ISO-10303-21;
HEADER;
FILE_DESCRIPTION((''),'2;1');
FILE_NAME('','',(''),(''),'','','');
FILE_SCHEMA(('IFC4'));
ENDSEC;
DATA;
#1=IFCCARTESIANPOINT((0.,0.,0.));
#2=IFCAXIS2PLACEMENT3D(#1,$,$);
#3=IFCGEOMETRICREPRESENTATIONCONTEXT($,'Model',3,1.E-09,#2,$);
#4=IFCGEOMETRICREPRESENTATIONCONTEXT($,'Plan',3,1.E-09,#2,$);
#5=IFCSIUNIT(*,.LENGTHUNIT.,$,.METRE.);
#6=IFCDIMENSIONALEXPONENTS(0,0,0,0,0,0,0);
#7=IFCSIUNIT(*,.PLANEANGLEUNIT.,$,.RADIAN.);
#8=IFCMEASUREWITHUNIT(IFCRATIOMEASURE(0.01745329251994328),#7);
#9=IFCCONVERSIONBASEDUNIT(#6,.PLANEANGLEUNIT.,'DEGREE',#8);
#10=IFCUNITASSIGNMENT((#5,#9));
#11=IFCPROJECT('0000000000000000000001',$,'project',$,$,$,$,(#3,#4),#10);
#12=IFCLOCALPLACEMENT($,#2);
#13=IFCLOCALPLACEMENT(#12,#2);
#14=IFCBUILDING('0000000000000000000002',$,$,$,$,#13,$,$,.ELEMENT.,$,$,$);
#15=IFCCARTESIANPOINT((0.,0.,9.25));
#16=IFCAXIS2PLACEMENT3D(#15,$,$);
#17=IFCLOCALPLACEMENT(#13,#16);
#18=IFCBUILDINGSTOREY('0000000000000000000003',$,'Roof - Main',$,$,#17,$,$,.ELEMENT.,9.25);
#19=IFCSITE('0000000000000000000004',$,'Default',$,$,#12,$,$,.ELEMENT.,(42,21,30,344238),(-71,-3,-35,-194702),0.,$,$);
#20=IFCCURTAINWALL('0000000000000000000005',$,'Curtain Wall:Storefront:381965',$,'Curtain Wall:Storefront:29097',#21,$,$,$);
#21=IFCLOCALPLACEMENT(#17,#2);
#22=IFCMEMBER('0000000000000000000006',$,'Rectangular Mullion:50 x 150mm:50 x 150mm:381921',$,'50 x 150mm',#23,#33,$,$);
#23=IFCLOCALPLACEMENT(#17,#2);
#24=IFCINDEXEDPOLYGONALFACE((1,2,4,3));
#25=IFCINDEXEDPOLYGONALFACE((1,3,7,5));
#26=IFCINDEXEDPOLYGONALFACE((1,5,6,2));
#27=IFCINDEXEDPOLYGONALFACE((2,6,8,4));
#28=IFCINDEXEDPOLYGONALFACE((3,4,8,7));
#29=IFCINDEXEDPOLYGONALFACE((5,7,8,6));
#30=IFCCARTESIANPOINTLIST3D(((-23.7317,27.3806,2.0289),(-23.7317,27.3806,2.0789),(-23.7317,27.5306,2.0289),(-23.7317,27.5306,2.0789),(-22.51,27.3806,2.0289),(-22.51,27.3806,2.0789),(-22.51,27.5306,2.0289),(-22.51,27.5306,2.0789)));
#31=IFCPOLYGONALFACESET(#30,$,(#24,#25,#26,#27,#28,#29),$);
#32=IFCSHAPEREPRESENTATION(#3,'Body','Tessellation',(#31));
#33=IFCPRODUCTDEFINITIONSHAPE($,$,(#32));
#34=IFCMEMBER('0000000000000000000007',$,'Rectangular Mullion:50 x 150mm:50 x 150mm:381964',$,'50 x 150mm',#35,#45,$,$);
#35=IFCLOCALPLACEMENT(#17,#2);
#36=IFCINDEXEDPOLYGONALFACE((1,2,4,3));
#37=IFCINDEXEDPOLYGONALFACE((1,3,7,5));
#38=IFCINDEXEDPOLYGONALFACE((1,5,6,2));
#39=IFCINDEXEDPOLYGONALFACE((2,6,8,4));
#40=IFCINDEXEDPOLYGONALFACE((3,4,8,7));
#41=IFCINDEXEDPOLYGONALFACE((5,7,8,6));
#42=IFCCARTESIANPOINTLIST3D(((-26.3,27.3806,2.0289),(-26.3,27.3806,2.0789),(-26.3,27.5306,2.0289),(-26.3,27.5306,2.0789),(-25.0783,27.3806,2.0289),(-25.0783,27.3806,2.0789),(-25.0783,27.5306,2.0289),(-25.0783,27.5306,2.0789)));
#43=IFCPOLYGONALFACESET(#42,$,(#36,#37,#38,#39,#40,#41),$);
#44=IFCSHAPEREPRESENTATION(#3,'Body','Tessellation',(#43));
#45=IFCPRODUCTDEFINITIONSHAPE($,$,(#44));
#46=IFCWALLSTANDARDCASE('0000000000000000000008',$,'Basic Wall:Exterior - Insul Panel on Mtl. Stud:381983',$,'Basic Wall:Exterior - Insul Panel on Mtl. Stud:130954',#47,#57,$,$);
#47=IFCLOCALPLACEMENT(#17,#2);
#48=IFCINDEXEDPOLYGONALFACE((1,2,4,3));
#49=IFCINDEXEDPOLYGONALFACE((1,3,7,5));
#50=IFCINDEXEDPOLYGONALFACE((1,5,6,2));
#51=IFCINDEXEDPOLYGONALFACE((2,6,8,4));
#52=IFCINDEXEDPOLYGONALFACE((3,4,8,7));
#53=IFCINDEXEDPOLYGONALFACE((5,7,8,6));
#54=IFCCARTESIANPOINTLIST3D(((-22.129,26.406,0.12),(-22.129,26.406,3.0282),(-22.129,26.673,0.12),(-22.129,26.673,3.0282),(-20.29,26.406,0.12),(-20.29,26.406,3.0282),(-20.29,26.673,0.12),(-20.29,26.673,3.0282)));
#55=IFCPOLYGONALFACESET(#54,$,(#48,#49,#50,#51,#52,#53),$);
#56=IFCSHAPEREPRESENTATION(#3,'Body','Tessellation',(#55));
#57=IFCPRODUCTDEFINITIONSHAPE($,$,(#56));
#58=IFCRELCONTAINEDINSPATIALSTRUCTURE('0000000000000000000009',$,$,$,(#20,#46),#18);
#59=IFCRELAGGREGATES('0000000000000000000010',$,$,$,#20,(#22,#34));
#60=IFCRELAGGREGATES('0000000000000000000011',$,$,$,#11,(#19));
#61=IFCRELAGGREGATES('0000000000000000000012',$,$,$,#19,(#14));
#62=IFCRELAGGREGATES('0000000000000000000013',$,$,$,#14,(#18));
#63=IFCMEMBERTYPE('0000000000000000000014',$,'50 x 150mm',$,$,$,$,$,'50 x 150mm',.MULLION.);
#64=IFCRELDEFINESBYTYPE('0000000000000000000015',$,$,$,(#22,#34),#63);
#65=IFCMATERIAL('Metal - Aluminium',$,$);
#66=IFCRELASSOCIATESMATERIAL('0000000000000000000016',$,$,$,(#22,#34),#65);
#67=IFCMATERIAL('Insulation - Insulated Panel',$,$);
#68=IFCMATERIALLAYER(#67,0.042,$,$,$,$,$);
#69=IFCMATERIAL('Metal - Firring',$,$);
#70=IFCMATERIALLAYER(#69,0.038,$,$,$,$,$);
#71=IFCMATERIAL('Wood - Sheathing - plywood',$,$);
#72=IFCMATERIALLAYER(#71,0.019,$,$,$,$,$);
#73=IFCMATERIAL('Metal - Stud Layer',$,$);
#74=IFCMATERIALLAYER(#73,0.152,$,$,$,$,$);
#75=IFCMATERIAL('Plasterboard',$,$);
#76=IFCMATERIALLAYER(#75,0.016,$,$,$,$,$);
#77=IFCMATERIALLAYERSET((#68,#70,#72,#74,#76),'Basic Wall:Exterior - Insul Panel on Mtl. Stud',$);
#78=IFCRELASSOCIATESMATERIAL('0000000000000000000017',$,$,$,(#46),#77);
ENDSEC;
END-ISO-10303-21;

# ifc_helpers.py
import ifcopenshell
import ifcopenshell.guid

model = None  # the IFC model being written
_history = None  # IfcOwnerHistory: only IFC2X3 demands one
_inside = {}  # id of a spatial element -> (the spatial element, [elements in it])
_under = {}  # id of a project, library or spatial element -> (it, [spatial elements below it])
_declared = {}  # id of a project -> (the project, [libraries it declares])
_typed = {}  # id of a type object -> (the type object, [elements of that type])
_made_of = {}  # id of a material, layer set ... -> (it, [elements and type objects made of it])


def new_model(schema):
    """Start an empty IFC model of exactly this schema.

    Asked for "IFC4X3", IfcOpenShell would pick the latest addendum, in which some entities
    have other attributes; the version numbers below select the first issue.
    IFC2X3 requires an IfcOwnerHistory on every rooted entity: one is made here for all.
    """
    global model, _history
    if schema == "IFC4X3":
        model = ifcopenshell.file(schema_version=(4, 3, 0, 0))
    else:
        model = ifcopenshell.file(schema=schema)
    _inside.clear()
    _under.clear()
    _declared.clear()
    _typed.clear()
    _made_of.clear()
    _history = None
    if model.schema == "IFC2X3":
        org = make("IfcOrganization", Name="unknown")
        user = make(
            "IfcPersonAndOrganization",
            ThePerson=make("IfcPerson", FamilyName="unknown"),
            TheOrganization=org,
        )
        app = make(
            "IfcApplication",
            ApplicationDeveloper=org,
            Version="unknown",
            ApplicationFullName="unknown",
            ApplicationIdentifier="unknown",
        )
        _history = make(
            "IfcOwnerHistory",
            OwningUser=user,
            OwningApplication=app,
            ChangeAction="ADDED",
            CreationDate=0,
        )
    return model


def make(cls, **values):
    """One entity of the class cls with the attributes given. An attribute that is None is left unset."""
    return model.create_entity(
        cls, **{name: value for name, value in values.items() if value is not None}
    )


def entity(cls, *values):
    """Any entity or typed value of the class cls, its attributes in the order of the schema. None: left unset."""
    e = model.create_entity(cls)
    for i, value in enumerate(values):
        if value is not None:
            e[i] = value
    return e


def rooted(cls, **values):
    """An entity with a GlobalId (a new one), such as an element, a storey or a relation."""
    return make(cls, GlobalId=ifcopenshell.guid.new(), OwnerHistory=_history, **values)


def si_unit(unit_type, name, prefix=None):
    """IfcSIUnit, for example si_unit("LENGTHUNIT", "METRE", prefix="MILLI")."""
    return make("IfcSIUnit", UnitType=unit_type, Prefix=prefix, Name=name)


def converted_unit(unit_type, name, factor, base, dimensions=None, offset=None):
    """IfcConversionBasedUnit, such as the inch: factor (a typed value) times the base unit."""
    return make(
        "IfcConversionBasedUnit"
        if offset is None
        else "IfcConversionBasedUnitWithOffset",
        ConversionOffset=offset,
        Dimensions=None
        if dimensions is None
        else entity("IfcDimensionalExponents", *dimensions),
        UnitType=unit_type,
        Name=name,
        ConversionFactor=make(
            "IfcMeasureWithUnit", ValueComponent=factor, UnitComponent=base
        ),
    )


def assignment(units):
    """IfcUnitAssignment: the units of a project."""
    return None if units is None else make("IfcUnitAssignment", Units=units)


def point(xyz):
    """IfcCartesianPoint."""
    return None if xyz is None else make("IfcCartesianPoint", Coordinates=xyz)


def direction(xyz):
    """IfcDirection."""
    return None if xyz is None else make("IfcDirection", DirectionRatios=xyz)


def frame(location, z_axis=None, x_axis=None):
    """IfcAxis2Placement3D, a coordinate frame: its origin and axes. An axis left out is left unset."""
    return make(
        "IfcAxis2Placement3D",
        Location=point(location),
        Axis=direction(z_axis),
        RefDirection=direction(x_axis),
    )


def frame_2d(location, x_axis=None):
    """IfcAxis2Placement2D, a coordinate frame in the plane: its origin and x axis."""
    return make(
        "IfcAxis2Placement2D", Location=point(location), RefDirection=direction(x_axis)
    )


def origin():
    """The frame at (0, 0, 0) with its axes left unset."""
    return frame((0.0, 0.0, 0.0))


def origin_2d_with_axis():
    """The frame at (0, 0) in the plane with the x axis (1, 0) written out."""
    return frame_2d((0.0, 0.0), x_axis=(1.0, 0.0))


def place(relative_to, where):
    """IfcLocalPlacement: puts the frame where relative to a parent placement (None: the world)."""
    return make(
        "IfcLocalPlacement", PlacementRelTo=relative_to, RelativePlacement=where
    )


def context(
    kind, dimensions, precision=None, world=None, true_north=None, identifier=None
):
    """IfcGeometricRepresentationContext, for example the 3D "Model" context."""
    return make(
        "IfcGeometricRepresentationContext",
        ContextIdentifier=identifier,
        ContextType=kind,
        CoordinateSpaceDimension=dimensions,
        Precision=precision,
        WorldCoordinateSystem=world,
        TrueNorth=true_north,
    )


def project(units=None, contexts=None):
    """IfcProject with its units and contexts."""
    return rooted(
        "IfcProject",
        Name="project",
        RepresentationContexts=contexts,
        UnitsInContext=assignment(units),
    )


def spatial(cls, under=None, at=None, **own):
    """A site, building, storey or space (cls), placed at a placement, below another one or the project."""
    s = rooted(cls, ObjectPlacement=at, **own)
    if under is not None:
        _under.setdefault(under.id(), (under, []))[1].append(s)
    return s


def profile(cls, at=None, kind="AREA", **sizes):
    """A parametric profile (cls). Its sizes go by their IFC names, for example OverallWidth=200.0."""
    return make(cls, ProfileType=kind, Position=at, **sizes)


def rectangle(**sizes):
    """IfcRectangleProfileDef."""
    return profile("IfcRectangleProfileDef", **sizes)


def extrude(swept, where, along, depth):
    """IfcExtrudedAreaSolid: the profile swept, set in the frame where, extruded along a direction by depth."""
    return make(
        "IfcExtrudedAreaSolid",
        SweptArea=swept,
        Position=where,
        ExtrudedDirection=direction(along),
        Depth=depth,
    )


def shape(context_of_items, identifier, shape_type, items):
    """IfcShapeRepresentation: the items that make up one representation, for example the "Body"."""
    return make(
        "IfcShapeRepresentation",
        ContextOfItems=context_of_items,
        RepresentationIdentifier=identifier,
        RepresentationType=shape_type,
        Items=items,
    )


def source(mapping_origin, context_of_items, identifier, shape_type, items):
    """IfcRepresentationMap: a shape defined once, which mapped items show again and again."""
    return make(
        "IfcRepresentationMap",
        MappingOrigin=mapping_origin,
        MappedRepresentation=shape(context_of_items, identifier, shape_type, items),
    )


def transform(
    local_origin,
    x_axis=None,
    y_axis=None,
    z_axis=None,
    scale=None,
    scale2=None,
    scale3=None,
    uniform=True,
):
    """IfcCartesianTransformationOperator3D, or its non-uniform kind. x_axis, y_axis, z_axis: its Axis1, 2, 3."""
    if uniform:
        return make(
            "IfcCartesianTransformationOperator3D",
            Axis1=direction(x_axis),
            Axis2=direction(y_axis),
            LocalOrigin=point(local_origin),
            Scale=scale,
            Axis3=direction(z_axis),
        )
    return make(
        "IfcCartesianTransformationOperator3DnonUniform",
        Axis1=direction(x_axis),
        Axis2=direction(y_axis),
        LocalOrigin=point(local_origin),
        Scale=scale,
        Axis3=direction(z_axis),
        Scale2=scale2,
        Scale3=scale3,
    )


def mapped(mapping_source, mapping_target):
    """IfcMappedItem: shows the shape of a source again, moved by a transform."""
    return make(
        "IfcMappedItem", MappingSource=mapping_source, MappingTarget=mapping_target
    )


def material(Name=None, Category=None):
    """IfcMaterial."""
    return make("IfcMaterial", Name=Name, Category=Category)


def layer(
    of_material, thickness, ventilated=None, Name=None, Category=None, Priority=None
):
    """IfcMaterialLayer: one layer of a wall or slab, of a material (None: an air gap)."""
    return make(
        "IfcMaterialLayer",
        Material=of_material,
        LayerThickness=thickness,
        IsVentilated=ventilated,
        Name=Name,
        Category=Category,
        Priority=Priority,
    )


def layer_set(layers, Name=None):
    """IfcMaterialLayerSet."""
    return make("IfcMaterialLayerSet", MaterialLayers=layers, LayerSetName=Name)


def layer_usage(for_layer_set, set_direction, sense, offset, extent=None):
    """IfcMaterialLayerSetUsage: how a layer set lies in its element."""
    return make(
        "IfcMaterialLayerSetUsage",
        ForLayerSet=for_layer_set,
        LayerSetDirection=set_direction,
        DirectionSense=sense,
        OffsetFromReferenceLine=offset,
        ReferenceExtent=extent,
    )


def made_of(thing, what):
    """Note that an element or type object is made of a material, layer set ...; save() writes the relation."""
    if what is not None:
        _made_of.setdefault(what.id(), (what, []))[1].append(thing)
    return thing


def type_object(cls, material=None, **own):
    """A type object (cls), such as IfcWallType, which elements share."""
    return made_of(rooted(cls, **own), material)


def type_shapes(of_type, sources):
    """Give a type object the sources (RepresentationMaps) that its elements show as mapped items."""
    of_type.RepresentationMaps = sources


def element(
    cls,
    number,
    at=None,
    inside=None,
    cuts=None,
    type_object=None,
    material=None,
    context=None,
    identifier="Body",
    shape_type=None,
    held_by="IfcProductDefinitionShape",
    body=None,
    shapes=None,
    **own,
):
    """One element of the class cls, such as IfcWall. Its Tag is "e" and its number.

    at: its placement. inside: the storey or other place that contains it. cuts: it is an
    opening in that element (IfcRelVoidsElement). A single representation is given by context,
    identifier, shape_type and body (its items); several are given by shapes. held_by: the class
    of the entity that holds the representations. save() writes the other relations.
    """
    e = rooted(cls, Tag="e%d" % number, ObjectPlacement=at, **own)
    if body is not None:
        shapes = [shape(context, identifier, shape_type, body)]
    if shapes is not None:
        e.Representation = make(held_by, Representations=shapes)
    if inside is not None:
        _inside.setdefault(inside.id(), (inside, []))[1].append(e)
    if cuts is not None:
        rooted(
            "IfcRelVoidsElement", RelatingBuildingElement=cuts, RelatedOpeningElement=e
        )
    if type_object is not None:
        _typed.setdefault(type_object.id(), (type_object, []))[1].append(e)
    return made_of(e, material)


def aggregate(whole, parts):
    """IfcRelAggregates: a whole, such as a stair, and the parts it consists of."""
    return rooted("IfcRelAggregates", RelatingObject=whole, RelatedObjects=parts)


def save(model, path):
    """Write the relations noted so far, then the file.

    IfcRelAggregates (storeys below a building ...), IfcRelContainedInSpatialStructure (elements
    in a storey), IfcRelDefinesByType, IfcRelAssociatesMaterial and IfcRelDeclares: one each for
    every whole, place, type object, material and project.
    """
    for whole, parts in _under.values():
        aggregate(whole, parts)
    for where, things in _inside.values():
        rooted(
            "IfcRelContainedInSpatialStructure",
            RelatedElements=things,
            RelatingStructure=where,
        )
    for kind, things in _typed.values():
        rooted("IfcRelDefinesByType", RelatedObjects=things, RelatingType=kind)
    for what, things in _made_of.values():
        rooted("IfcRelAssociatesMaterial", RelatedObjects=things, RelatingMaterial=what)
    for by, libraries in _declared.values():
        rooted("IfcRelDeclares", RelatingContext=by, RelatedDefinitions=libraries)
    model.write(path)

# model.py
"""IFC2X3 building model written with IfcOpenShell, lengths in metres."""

from ifc_helpers import new_model, entity, si_unit, converted_unit, frame, frame_2d, origin, origin_2d_with_axis, place, context, project, spatial, rectangle, extrude, source, transform, mapped, material, layer, layer_set, layer_usage, type_object, type_shapes, element, aggregate, save


model = new_model("IFC2X3")

# Units and contexts
model_context = context("Model", 3, precision=1e-09, world=origin())
plan_context = context("Plan", 3, precision=1e-09, world=origin())
ifc_project = project(units=[si_unit("LENGTHUNIT", "METRE"), converted_unit("PLANEANGLEUNIT", "DEGREE", entity("IfcRatioMeasure", 0.01745329251994328), si_unit("PLANEANGLEUNIT", "RADIAN"), dimensions=[0, 0, 0, 0, 0, 0, 0])], contexts=[model_context, plan_context])

# Site, building, storey
site_placement = place(None, origin())
site = spatial("IfcSite", under=ifc_project, at=site_placement, Name="Default", CompositionType="ELEMENT", RefLatitude=(42, 21, 30, 344238), RefLongitude=(-71, -3, -35, -194702), RefElevation=0.0)
building_placement = place(site_placement, origin())
building = spatial("IfcBuilding", under=site, at=building_placement, CompositionType="ELEMENT")
storey_placement = place(building_placement, frame((0.0, 0.0, 9.25)))
storey = spatial("IfcBuildingStorey", under=building, at=storey_placement, Name="Roof - Main", CompositionType="ELEMENT", Elevation=9.25)

# Shared definitions
ifc_material_1 = material(Name="Metal - Aluminium")

# Curtain wall, members
curtain_wall_1_placement = place(storey_placement, origin())
curtain_wall_1 = element("IfcCurtainWall", 1, at=curtain_wall_1_placement, inside=storey, Name="Curtain Wall:Storefront:381965", ObjectType="Curtain Wall:Storefront:29097")
member_type_1 = type_object("IfcMemberType", Name="50 x 150mm", ElementType="50 x 150mm", PredefinedType="MULLION")
shared_shape_1 = source(origin(), model_context, "Body", "SweptSolid", [
    extrude(rectangle(XDim=0.05, YDim=0.15, at=origin_2d_with_axis()), frame((0.0, 0.0, -1.2217), z_axis=(0.0, 0.0, 1.0), x_axis=(-1.0, 0.0, 0.0)), (0.0, 0.0, 1.0), 1.2217),
])
type_shapes(member_type_1, [shared_shape_1])
member_1_placement = place(storey_placement, frame((-22.51, 27.4556, 2.0539), z_axis=(1.0, 0.0, 0.0), x_axis=(0.0, 0.0, 1.0)))
member_1 = element("IfcMember", 2, at=member_1_placement, type_object=member_type_1, material=ifc_material_1, Name="Rectangular Mullion:50 x 150mm:50 x 150mm:381921", ObjectType="50 x 150mm", context=model_context, shape_type="MappedRepresentation", body=[
    mapped(shared_shape_1, transform((0.0, 0.0, 0.0), scale=1.0)),
])
member_2_placement = place(storey_placement, frame((-25.0783, 27.4556, 2.0539), z_axis=(1.0, 0.0, 0.0), x_axis=(0.0, 0.0, 1.0)))
member_2 = element("IfcMember", 3, at=member_2_placement, type_object=member_type_1, material=ifc_material_1, Name="Rectangular Mullion:50 x 150mm:50 x 150mm:381964", ObjectType="50 x 150mm", context=model_context, shape_type="MappedRepresentation", body=[
    mapped(shared_shape_1, transform((0.0, 0.0, 0.0), scale=1.0)),
])
aggregate(curtain_wall_1, [member_1, member_2])

# Wall
ifc_material_2 = material(Name="Insulation - Insulated Panel")
ifc_layer_1 = layer(ifc_material_2, 0.042)
ifc_material_3 = material(Name="Metal - Firring")
ifc_layer_2 = layer(ifc_material_3, 0.038)
ifc_material_4 = material(Name="Wood - Sheathing - plywood")
ifc_layer_3 = layer(ifc_material_4, 0.019)
ifc_material_5 = material(Name="Metal - Stud Layer")
ifc_layer_4 = layer(ifc_material_5, 0.152)
ifc_material_6 = material(Name="Plasterboard")
ifc_layer_5 = layer(ifc_material_6, 0.016)
ifc_layer_set = layer_set([ifc_layer_1, ifc_layer_2, ifc_layer_3, ifc_layer_4, ifc_layer_5], Name="Basic Wall:Exterior - Insul Panel on Mtl. Stud")
ifc_layer_usage = layer_usage(ifc_layer_set, "AXIS2", "POSITIVE", -0.1335)
wall_placement = place(storey_placement, frame((-22.129, 26.5395, 0.12)))
element("IfcWallStandardCase", 4, at=wall_placement, inside=storey, material=ifc_layer_usage, Name="Basic Wall:Exterior - Insul Panel on Mtl. Stud:381983", ObjectType="Basic Wall:Exterior - Insul Panel on Mtl. Stud:130954", context=model_context, shape_type="SweptSolid", body=[
    extrude(rectangle(XDim=1.839, YDim=0.267, at=frame_2d((0.9195, 0.0), x_axis=(-1.0, 0.0))), origin(), (0.0, 0.0, 1.0), 2.9082),
])

save(model, "model.ifc")
